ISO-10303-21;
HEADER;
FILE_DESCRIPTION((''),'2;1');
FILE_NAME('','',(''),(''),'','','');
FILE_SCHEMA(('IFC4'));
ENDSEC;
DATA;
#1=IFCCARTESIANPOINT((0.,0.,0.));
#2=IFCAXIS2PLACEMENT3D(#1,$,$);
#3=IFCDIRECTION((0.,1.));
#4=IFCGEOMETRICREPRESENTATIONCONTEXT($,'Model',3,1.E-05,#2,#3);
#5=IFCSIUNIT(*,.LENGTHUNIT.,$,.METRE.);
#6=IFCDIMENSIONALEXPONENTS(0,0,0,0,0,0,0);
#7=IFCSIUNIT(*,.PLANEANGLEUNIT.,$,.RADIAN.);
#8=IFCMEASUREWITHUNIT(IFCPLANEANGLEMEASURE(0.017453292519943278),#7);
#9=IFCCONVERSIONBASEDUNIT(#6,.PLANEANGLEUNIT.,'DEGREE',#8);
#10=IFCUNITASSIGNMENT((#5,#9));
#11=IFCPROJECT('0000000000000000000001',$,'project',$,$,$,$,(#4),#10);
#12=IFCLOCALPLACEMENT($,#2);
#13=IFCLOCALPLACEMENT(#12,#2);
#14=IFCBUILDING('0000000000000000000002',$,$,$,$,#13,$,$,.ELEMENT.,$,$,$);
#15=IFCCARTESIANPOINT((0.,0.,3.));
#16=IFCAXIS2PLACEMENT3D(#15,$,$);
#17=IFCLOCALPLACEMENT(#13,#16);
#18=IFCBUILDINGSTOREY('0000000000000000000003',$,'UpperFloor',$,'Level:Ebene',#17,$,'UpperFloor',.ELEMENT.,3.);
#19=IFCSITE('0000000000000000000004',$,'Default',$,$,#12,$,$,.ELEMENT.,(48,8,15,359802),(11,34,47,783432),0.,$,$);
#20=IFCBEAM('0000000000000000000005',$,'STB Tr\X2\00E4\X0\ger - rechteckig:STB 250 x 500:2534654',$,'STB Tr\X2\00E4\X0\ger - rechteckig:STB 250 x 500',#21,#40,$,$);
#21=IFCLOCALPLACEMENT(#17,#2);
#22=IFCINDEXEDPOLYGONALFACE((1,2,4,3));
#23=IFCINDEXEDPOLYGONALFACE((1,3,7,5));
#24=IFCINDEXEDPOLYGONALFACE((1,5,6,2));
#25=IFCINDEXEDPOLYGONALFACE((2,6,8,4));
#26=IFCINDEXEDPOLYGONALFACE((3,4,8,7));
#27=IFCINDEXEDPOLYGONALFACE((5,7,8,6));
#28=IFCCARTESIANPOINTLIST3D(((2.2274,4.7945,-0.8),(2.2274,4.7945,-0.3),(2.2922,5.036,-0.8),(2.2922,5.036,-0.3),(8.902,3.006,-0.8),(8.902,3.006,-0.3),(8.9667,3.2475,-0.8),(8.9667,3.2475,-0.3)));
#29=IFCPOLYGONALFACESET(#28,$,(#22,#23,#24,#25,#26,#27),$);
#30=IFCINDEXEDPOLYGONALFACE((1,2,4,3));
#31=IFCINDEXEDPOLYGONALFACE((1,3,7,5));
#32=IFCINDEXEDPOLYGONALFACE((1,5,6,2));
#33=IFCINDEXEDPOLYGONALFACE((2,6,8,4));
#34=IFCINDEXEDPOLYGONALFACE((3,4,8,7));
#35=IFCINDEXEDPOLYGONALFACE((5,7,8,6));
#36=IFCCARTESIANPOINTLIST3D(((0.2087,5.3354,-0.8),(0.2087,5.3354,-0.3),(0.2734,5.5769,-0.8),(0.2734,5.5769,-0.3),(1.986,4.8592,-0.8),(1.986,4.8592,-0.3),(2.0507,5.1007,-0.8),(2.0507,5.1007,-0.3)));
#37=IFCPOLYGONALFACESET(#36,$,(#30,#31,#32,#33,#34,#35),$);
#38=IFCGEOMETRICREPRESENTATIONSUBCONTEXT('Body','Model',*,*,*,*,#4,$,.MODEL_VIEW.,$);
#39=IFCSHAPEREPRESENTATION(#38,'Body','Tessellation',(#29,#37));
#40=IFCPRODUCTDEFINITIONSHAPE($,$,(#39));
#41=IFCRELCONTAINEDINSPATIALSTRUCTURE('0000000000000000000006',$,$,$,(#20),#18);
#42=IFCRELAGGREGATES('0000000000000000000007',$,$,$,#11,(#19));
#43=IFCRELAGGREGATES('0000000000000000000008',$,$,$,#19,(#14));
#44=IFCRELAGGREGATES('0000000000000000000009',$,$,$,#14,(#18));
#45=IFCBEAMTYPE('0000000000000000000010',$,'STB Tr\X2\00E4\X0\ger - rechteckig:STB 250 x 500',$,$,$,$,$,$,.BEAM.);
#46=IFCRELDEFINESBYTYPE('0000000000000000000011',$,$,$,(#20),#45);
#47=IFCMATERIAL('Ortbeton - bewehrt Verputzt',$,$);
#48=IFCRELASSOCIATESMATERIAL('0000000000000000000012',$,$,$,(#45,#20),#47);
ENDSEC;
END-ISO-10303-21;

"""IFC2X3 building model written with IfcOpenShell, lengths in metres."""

from ifc_helpers import new_model, entity, si_unit, converted_unit, direction, frame, frame_2d, origin, origin_2d_with_axis, place, context, subcontext, project, spatial, rectangle, extrude, source, transform, mapped, material, type_object, type_shapes, element, save


model = new_model("IFC2X3")

# Units and contexts
model_context = context("Model", 3, precision=1e-05, world=origin(), true_north=direction((0.0, 1.0)))
body_context = subcontext(model_context, "Body", "Model", "MODEL_VIEW")
ifc_project = project(units=[si_unit("LENGTHUNIT", "METRE"), converted_unit("PLANEANGLEUNIT", "DEGREE", entity("IfcPlaneAngleMeasure", 0.017453292519943278), si_unit("PLANEANGLEUNIT", "RADIAN"), dimensions=[0, 0, 0, 0, 0, 0, 0])], contexts=[model_context])

# Site, building, storey
site_placement = place(None, origin())
site = spatial("IfcSite", under=ifc_project, at=site_placement, Name="Default", CompositionType="ELEMENT", RefLatitude=(48, 8, 15, 359802), RefLongitude=(11, 34, 47, 783432), RefElevation=0.0)
building_placement = place(site_placement, origin())
building = spatial("IfcBuilding", under=site, at=building_placement, CompositionType="ELEMENT")
storey_placement = place(building_placement, frame((0.0, 0.0, 3.0)))
storey = spatial("IfcBuildingStorey", under=building, at=storey_placement, Name="UpperFloor", ObjectType="Level:Ebene", LongName="UpperFloor", CompositionType="ELEMENT", Elevation=3.0)

# Beam
ifc_material = material(Name="Ortbeton - bewehrt Verputzt")
beam_type = type_object("IfcBeamType", Name="STB Träger - rechteckig:STB 250 x 500", PredefinedType="BEAM", material=ifc_material)
shared_shape = source(origin(), body_context, "Body", "SweptSolid", [
    extrude(rectangle(XDim=0.5, YDim=0.25, at=origin_2d_with_axis()), frame((2.2598, 4.9152, 2.45), z_axis=(0.965926, -0.258819, 0.0), x_axis=(0.0, 0.0, -1.0)), (0.0, 0.0, 1.0), 6.91),
    extrude(rectangle(XDim=0.5, YDim=0.25, at=frame_2d((0.0, 0.0), x_axis=(1.0, 0.0))), frame((0.241, 5.4561, 2.45), z_axis=(0.965926, -0.258819, 0.0), x_axis=(0.0, 0.0, -1.0)), (0.0, 0.0, 1.0), 1.84),
])
type_shapes(beam_type, [shared_shape])
beam_placement = place(storey_placement, frame((0.0, 0.0, -3.0)))
element("IfcBeam", 1, at=beam_placement, inside=storey, type_object=beam_type, material=ifc_material, Name="STB Träger - rechteckig:STB 250 x 500:2534654", ObjectType="STB Träger - rechteckig:STB 250 x 500", context=body_context, shape_type="MappedRepresentation", body=[
    mapped(shared_shape, transform((0.0, 0.0, 0.0), scale=1.0)),
])

save(model, "model.ifc")
